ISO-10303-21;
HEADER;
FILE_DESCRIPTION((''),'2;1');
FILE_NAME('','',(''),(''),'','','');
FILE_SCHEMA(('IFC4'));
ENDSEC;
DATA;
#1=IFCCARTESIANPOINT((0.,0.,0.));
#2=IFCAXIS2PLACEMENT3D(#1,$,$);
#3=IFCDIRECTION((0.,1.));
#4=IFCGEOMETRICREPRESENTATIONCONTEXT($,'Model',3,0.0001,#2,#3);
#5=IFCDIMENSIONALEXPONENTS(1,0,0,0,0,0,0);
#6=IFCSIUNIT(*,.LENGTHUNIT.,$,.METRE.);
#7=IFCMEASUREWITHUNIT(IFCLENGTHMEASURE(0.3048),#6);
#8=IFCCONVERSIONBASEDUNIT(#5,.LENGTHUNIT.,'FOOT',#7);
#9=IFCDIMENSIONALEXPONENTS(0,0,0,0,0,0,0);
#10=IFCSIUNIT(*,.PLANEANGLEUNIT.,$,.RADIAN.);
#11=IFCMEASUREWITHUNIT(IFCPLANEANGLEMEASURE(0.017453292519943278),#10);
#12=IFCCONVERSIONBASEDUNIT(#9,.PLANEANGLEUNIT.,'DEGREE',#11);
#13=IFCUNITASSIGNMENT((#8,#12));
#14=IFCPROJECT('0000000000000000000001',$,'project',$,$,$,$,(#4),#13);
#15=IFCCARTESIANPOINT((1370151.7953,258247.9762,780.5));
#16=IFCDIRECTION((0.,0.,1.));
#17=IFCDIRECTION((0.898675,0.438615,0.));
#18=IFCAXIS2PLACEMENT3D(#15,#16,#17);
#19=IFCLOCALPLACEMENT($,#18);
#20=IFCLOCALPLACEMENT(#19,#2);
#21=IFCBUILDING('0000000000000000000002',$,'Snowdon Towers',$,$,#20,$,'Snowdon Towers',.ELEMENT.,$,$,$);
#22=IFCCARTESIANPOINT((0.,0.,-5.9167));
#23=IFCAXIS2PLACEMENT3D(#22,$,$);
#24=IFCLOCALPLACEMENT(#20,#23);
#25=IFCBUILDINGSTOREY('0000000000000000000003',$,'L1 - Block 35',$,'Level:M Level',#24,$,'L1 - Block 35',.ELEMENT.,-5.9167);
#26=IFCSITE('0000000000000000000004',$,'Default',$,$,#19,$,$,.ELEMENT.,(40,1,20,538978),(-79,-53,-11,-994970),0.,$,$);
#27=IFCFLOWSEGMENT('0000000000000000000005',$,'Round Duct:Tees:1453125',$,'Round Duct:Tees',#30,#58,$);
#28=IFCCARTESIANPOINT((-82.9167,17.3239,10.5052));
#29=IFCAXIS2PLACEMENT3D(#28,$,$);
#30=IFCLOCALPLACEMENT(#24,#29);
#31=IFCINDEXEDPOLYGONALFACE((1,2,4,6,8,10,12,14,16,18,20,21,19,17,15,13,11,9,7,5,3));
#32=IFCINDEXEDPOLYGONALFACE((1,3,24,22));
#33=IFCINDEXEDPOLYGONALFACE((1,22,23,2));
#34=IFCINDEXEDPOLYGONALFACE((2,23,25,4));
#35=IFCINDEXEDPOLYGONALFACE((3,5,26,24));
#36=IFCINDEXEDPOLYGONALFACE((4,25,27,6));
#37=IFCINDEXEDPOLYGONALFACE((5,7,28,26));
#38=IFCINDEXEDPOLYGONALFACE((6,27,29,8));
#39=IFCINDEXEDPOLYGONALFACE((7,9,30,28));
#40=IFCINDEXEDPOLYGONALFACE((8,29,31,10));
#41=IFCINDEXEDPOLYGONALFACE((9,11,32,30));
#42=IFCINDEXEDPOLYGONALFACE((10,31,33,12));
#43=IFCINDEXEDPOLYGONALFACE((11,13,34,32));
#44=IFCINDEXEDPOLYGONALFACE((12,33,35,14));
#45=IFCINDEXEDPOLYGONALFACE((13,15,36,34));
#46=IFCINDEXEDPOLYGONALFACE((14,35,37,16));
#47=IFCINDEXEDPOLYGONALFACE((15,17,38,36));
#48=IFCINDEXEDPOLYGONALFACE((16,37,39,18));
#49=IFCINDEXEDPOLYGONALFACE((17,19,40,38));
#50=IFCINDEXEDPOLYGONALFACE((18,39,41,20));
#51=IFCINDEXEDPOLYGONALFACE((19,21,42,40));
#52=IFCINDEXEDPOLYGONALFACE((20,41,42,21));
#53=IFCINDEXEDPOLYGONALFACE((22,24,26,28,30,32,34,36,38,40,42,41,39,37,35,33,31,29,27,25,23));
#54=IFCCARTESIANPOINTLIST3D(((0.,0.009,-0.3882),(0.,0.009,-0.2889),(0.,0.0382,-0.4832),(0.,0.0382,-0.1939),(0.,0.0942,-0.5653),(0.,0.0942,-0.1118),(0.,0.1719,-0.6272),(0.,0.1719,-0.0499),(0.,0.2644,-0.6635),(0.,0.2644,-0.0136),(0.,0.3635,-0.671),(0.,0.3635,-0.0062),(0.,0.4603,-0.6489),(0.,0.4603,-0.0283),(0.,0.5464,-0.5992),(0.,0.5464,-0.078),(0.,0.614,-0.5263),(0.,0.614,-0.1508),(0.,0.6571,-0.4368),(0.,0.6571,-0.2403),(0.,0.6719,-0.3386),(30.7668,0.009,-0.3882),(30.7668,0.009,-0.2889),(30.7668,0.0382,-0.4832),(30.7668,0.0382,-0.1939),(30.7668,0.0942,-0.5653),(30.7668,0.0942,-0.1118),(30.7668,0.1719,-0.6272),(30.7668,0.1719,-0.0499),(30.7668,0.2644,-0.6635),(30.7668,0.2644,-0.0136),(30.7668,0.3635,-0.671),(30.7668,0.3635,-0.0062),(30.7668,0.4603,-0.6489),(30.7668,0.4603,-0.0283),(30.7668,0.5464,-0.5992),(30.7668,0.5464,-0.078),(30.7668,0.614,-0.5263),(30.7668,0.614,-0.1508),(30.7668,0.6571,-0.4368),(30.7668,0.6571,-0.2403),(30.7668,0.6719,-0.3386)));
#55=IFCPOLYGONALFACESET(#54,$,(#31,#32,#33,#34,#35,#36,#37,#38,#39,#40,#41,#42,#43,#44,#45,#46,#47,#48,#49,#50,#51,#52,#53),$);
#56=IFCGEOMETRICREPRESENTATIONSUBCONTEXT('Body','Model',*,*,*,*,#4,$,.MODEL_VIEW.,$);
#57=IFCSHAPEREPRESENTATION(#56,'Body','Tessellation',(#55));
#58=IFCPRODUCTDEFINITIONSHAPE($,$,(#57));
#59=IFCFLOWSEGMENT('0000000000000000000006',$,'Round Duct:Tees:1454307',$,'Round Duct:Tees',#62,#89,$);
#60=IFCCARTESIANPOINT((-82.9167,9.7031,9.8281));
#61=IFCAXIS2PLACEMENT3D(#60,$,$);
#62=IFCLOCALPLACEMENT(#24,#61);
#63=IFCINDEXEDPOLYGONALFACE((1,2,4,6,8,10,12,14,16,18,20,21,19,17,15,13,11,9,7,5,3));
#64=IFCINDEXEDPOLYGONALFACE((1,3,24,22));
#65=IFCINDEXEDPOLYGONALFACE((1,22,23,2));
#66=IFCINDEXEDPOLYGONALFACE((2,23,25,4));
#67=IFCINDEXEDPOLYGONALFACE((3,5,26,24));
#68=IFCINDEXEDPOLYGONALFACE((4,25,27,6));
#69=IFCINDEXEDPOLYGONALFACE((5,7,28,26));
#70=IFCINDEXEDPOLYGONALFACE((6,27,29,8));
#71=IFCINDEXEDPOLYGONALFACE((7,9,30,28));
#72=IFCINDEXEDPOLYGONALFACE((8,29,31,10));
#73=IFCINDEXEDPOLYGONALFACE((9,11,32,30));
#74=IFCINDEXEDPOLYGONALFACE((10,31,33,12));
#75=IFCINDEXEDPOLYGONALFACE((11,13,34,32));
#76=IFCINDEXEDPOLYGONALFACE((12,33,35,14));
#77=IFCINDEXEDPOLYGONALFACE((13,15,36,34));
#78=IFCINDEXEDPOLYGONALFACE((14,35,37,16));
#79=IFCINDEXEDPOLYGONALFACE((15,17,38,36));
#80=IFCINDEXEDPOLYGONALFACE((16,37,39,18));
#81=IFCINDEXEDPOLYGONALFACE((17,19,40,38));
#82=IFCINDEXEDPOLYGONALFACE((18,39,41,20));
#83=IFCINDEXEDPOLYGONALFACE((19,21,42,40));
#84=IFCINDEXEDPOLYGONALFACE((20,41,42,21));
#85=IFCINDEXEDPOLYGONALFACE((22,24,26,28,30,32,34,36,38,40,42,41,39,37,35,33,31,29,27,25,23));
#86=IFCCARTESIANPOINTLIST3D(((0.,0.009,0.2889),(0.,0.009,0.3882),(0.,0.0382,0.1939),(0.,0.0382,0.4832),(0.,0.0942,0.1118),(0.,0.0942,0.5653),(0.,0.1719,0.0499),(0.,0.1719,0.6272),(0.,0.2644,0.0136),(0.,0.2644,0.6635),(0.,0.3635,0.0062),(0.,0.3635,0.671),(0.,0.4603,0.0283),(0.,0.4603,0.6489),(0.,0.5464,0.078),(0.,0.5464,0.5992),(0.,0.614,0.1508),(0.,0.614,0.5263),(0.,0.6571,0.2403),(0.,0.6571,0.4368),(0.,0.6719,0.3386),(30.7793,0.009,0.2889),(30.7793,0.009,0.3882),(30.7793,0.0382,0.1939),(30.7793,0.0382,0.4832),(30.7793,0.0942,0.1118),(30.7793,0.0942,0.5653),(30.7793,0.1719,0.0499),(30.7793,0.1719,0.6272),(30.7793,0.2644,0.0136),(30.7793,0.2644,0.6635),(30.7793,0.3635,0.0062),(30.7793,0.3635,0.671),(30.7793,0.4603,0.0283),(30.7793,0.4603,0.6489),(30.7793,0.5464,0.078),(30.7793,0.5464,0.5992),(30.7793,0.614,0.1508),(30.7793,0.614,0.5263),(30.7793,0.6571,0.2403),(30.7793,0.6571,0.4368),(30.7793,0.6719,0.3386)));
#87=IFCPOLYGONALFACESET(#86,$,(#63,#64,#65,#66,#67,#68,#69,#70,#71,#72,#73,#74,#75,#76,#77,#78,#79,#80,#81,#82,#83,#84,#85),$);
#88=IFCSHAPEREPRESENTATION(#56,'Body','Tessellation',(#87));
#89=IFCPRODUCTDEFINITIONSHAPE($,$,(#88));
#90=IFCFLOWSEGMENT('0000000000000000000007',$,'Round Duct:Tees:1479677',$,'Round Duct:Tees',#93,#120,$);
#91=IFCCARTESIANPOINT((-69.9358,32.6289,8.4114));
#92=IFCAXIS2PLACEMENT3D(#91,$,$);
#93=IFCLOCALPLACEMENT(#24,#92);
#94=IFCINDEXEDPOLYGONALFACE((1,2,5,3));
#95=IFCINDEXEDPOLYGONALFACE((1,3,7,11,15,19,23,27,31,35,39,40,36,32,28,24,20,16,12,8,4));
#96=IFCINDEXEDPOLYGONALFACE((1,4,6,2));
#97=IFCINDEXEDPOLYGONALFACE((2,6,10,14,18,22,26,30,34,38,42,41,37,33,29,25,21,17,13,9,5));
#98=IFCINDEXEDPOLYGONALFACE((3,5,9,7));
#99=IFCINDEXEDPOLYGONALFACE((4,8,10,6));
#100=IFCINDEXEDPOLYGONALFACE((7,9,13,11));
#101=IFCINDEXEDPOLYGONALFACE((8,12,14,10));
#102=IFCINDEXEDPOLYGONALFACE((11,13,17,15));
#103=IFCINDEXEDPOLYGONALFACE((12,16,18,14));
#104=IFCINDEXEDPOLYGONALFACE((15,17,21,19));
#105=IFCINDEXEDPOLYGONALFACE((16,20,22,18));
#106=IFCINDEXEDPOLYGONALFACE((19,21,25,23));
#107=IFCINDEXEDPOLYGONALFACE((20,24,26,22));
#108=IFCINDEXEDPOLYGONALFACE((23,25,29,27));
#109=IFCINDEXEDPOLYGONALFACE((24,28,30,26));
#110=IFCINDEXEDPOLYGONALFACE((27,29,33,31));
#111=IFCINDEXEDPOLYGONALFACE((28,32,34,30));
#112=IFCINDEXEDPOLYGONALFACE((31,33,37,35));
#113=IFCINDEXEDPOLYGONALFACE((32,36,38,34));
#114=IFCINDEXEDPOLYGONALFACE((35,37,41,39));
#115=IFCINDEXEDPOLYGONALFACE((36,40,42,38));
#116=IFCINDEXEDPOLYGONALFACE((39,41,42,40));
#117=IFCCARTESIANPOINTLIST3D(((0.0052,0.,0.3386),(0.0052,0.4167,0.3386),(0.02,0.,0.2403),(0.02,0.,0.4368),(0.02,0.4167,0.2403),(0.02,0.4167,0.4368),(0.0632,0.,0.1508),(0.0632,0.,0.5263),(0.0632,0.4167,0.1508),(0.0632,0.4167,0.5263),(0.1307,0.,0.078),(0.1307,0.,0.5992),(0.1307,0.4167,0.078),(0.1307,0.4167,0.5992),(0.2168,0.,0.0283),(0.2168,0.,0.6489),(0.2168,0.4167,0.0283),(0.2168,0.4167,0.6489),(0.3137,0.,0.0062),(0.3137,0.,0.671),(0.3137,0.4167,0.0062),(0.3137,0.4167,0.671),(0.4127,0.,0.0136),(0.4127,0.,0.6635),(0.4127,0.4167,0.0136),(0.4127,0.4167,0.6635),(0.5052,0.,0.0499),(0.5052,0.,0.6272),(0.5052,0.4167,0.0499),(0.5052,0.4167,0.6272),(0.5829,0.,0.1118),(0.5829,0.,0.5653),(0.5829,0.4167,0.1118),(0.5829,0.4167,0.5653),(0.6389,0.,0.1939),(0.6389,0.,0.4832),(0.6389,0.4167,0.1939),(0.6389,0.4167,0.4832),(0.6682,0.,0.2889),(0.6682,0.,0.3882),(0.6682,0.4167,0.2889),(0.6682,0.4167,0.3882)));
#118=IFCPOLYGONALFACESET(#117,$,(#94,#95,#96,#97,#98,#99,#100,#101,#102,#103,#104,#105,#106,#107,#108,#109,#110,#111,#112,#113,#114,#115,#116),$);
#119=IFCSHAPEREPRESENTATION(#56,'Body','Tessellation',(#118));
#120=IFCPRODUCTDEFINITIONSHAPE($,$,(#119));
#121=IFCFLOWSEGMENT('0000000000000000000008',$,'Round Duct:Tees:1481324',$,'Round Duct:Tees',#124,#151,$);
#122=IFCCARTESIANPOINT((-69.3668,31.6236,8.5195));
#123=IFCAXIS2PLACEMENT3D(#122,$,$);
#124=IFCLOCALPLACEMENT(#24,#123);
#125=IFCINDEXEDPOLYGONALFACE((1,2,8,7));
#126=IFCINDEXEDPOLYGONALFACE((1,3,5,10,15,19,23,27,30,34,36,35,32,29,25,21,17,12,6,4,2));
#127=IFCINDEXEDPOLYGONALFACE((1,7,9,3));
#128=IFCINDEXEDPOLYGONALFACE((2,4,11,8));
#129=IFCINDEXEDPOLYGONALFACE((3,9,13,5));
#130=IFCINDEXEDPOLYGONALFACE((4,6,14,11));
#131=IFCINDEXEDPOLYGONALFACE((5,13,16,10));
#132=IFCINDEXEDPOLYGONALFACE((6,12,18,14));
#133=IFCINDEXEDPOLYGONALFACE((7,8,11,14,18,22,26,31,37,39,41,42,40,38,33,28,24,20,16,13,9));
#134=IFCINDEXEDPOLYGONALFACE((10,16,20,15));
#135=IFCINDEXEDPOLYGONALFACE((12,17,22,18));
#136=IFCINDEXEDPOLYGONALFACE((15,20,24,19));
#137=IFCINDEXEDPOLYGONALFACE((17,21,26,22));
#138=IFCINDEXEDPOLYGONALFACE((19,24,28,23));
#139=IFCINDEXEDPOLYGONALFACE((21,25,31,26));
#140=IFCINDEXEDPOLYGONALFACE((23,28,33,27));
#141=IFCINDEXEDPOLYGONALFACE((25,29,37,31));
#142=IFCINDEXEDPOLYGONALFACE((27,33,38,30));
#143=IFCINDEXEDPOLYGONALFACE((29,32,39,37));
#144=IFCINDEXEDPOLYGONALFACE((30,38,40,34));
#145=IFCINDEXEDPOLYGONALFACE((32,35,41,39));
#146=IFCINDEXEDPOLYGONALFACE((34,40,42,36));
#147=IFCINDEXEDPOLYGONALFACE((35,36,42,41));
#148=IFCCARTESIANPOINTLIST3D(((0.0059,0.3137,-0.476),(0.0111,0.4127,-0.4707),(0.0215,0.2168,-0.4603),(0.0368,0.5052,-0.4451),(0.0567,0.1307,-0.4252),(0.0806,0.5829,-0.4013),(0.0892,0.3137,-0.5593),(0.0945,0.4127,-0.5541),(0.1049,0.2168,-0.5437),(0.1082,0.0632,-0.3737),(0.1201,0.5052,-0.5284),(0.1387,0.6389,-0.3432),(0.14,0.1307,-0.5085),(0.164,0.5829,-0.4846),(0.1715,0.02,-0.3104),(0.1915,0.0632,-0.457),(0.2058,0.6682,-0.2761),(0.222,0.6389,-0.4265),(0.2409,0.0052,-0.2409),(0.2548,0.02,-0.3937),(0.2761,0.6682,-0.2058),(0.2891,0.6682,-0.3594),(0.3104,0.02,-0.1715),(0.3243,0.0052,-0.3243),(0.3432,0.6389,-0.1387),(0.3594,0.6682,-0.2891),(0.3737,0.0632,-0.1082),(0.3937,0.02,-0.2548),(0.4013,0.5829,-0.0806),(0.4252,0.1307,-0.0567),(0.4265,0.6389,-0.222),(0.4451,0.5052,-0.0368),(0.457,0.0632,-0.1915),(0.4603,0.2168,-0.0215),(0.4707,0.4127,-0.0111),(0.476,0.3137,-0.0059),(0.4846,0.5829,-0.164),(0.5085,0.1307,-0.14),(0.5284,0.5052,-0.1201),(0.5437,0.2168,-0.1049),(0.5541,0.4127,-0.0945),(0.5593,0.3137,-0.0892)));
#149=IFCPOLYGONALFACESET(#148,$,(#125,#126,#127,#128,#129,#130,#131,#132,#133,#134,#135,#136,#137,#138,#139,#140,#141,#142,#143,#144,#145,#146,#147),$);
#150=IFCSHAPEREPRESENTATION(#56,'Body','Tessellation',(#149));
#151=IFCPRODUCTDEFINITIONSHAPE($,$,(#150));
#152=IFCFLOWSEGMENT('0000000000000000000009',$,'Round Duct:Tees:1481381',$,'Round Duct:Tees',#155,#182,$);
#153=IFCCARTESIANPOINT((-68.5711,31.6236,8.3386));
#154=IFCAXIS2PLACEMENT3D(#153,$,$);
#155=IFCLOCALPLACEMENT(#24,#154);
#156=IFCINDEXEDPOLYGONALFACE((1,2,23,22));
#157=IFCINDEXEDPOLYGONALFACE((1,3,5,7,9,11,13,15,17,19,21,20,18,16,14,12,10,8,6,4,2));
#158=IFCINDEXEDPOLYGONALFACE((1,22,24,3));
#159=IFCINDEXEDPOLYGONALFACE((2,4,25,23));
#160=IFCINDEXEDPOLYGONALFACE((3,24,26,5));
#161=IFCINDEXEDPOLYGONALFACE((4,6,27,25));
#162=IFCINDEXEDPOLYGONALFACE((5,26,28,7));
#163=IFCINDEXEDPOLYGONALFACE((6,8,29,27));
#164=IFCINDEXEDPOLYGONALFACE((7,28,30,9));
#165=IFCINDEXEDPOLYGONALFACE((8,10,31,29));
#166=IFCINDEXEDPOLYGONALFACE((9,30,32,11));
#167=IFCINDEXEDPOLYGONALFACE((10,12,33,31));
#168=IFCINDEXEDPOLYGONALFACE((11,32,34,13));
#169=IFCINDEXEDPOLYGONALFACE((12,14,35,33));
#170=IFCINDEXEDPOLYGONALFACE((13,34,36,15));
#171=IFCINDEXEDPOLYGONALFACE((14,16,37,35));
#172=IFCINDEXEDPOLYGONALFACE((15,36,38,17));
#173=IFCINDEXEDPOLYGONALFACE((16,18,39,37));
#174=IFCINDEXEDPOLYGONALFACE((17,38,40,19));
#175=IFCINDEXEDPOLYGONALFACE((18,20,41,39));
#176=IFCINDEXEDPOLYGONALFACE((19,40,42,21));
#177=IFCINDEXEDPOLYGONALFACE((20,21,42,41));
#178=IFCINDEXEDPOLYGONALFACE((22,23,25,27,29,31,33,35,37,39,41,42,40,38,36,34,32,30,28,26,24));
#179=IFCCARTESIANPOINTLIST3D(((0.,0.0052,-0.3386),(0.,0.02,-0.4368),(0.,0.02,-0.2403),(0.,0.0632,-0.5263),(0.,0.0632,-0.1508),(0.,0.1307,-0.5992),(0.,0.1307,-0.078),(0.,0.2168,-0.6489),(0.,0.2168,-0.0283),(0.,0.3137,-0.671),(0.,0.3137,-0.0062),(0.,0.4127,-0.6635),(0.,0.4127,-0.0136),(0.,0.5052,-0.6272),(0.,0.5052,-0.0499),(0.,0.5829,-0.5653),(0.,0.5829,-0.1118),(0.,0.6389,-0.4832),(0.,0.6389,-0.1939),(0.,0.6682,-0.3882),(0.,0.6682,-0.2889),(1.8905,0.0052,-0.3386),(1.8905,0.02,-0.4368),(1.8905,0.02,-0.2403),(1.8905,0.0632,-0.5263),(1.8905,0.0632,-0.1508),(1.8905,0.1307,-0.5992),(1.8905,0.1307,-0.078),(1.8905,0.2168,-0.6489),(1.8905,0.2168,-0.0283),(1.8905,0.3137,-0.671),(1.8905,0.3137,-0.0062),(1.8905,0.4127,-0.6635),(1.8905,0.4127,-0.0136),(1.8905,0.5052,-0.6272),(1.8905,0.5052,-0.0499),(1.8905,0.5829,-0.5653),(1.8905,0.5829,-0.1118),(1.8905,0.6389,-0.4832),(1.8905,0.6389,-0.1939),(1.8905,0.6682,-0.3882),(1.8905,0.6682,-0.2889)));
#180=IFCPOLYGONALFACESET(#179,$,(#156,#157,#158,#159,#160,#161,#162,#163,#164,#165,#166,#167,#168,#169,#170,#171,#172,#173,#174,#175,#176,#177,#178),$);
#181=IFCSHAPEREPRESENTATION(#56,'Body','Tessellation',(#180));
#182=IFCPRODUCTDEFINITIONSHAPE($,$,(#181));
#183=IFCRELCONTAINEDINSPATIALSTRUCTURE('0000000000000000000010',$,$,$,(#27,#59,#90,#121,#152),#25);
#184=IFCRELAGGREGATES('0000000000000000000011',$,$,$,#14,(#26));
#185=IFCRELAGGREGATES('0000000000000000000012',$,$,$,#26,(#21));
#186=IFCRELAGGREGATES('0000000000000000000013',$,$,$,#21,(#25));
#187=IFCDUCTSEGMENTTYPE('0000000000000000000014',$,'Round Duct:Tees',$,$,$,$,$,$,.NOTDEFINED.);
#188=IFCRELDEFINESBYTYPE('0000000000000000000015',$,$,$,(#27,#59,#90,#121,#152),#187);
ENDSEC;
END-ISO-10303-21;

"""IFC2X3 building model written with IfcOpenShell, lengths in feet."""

from ifc_helpers import new_model, entity, si_unit, converted_unit, direction, frame, frame_2d, origin, origin_2d_with_axis, place, context, subcontext, project, spatial, circle, extrude, type_object, element, save


model = new_model("IFC2X3")

# Units and contexts
model_context = context("Model", 3, precision=0.0001, world=origin(), true_north=direction((0.0, 1.0)))
body_context = subcontext(model_context, "Body", "Model", "MODEL_VIEW")
ifc_project = project(units=[converted_unit("LENGTHUNIT", "FOOT", entity("IfcLengthMeasure", 0.3048), si_unit("LENGTHUNIT", "METRE"), dimensions=[1, 0, 0, 0, 0, 0, 0]), converted_unit("PLANEANGLEUNIT", "DEGREE", entity("IfcPlaneAngleMeasure", 0.017453292519943278), si_unit("PLANEANGLEUNIT", "RADIAN"), dimensions=[0, 0, 0, 0, 0, 0, 0])], contexts=[model_context])

# Site, building, storey
site_placement = place(None, frame((1370151.7953, 258247.9762, 780.5), z_axis=(0.0, 0.0, 1.0), x_axis=(0.898675, 0.438615, 0.0)))
site = spatial("IfcSite", under=ifc_project, at=site_placement, Name="Default", CompositionType="ELEMENT", RefLatitude=(40, 1, 20, 538978), RefLongitude=(-79, -53, -11, -994970), RefElevation=0.0)
building_placement = place(site_placement, origin())
building = spatial("IfcBuilding", under=site, at=building_placement, Name="Snowdon Towers", LongName="Snowdon Towers", CompositionType="ELEMENT")
storey_placement = place(building_placement, frame((0.0, 0.0, -5.9167)))
storey = spatial("IfcBuildingStorey", under=building, at=storey_placement, Name="L1 - Block 35", ObjectType="Level:M Level", LongName="L1 - Block 35", CompositionType="ELEMENT", Elevation=-5.9167)

# Flow segments
duct_segment_type = type_object("IfcDuctSegmentType", Name="Round Duct:Tees", PredefinedType="NOTDEFINED")
flow_segment_1_placement = place(storey_placement, frame((-82.9167, 17.3239, 10.5052)))
element("IfcFlowSegment", 1, at=flow_segment_1_placement, inside=storey, type_object=duct_segment_type, Name="Round Duct:Tees:1453125", ObjectType="Round Duct:Tees", context=body_context, shape_type="SweptSolid", body=[
    extrude(circle(Radius=0.3333, at=frame_2d((0.0, 0.0), x_axis=(1.0, 0.0))), frame((0.0, 0.3386, -0.3386), z_axis=(1.0, 0.0, 0.0), x_axis=(0.0, 1.0, 0.0)), (0.0, 0.0, 1.0), 30.7668),
])
flow_segment_2_placement = place(storey_placement, frame((-82.9167, 9.7031, 9.8281)))
element("IfcFlowSegment", 2, at=flow_segment_2_placement, inside=storey, type_object=duct_segment_type, Name="Round Duct:Tees:1454307", ObjectType="Round Duct:Tees", context=body_context, shape_type="SweptSolid", body=[
    extrude(circle(Radius=0.3333, at=frame_2d((0.0, 0.0), x_axis=(1.0, 0.0))), frame((0.0, 0.3386, 0.3386), z_axis=(1.0, 0.0, 0.0), x_axis=(0.0, 1.0, 0.0)), (0.0, 0.0, 1.0), 30.7793),
])
flow_segment_3_placement = place(storey_placement, frame((-69.9358, 32.6289, 8.4114)))
element("IfcFlowSegment", 3, at=flow_segment_3_placement, inside=storey, type_object=duct_segment_type, Name="Round Duct:Tees:1479677", ObjectType="Round Duct:Tees", context=body_context, shape_type="SweptSolid", body=[
    extrude(circle(Radius=0.3333, at=frame_2d((0.0, 0.0), x_axis=(1.0, 0.0))), frame((0.3386, 0.0, 0.3386), z_axis=(0.0, 1.0, 0.0), x_axis=(-1.0, 0.0, 0.0)), (0.0, 0.0, 1.0), 0.4167),
])
flow_segment_4_placement = place(storey_placement, frame((-69.3668, 31.6236, 8.5195)))
element("IfcFlowSegment", 4, at=flow_segment_4_placement, inside=storey, type_object=duct_segment_type, Name="Round Duct:Tees:1481324", ObjectType="Round Duct:Tees", context=body_context, shape_type="SweptSolid", body=[
    extrude(circle(Radius=0.3333, at=frame_2d((0.0, 0.0), x_axis=(1.0, 0.0))), frame((0.2409, 0.3386, -0.2409), z_axis=(0.707107, 0.0, -0.707107), x_axis=(0.0, -1.0, 0.0)), (0.0, 0.0, 1.0), 0.1179),
])
flow_segment_5_placement = place(storey_placement, frame((-68.5711, 31.6236, 8.3386)))
element("IfcFlowSegment", 5, at=flow_segment_5_placement, inside=storey, type_object=duct_segment_type, Name="Round Duct:Tees:1481381", ObjectType="Round Duct:Tees", context=body_context, shape_type="SweptSolid", body=[
    extrude(circle(Radius=0.3333, at=origin_2d_with_axis()), frame((0.0, 0.3386, -0.3386), z_axis=(1.0, 0.0, 0.0), x_axis=(0.0, -1.0, 0.0)), (0.0, 0.0, 1.0), 1.8905),
])

save(model, "model.ifc")
